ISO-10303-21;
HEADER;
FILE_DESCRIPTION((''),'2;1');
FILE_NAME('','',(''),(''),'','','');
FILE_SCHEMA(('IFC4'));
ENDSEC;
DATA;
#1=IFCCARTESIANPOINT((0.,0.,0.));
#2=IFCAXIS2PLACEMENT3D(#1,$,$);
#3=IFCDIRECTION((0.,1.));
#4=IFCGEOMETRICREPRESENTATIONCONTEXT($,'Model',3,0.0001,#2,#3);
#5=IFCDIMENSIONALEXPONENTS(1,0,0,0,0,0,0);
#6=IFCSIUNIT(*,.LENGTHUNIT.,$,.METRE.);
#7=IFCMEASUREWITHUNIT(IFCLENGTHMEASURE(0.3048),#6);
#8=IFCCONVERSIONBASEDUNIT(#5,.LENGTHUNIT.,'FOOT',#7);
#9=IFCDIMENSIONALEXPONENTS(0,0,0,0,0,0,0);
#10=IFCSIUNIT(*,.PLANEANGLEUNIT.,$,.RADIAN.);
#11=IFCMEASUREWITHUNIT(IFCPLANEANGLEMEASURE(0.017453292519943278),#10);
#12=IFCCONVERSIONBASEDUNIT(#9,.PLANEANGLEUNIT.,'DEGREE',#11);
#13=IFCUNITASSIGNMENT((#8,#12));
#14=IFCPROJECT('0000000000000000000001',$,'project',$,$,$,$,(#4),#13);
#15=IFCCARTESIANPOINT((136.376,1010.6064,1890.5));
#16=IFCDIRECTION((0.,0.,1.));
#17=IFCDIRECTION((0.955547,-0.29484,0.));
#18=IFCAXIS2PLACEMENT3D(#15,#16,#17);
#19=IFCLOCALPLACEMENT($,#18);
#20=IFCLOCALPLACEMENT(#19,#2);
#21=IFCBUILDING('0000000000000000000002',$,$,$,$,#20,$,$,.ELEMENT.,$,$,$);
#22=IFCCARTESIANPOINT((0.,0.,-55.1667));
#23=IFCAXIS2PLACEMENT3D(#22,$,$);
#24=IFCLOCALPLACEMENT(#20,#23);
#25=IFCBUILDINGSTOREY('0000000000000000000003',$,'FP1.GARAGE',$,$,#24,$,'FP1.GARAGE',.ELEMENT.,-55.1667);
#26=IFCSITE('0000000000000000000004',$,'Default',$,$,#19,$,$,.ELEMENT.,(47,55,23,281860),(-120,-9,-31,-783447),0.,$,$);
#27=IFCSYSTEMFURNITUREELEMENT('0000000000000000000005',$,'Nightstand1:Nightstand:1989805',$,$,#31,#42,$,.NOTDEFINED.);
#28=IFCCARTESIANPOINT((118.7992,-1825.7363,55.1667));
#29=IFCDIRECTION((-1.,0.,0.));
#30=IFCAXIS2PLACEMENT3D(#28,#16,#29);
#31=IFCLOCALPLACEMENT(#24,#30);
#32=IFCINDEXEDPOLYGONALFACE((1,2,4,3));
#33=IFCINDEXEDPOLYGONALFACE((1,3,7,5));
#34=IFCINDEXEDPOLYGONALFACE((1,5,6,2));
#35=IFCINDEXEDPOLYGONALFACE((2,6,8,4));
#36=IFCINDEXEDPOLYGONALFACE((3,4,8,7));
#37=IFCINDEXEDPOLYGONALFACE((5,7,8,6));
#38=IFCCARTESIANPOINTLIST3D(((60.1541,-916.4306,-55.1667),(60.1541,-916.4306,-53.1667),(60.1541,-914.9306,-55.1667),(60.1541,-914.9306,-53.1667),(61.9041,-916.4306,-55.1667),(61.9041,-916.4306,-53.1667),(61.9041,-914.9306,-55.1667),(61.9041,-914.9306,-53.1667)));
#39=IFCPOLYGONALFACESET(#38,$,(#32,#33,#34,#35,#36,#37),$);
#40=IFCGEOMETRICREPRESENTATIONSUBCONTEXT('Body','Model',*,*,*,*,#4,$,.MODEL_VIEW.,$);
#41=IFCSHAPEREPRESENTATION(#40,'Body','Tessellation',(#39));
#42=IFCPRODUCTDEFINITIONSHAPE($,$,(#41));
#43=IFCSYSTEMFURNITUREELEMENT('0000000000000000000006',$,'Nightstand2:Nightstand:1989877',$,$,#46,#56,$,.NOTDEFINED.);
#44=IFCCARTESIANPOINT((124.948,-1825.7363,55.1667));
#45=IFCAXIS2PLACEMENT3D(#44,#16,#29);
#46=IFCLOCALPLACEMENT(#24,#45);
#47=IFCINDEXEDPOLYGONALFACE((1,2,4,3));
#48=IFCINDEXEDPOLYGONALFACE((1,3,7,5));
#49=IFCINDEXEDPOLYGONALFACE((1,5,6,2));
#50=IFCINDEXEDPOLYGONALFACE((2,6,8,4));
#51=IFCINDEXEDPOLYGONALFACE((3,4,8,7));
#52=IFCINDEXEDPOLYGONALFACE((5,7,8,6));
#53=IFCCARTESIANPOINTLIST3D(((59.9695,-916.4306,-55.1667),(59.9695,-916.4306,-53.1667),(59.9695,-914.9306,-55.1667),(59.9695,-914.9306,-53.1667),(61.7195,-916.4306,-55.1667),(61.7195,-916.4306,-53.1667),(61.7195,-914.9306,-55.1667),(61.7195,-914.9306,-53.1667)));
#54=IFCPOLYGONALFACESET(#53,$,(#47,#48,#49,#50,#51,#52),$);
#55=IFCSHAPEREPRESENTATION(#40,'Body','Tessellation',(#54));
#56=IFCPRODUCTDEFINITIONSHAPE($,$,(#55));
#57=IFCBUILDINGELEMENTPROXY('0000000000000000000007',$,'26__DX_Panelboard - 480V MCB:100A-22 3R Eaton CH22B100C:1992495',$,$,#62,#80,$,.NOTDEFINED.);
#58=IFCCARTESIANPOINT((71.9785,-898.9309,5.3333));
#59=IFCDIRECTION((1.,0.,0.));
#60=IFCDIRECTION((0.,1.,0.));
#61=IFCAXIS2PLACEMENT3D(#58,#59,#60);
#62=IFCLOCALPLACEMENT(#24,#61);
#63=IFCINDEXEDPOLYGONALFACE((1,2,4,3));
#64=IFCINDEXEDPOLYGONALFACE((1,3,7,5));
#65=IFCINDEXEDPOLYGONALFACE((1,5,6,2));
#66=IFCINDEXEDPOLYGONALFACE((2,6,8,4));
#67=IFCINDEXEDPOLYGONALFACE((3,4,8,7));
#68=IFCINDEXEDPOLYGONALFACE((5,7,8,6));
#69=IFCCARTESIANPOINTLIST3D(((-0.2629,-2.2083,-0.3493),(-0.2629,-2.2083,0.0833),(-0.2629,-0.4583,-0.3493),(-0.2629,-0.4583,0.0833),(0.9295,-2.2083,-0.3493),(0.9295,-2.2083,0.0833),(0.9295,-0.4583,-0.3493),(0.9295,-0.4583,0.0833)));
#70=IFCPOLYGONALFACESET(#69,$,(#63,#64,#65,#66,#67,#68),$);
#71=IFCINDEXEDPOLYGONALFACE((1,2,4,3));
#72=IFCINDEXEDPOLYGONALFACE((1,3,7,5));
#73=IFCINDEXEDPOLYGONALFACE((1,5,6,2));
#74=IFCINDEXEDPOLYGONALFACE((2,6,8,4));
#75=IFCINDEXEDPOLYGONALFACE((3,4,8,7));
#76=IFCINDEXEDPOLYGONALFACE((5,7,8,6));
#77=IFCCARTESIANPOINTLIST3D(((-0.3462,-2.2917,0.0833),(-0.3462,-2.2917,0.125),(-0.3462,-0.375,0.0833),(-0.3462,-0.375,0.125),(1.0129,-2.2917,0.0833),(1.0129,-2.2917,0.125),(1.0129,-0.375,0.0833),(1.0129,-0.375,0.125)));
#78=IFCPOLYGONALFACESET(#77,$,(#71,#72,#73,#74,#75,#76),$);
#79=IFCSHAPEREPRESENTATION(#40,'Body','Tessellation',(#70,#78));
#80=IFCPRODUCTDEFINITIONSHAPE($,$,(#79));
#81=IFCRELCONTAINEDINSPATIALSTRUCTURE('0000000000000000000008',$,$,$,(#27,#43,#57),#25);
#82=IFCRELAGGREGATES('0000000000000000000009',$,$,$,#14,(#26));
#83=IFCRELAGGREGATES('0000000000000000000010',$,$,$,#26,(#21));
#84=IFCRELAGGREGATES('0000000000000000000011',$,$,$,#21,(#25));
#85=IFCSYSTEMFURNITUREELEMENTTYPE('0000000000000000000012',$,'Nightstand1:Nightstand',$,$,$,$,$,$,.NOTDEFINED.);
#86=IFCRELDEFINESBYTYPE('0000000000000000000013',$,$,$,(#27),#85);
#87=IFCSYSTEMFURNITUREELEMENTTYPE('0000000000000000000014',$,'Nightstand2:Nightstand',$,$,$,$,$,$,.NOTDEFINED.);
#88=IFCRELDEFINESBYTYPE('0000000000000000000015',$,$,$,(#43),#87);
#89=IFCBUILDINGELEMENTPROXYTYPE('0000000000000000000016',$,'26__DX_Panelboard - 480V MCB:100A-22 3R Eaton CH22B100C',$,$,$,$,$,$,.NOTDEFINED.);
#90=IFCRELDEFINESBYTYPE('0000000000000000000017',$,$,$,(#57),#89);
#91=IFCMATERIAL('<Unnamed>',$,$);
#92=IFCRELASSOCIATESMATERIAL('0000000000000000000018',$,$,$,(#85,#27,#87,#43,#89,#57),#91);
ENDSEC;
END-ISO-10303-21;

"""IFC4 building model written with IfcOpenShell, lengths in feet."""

from ifc_helpers import new_model, entity, si_unit, converted_unit, direction, frame, origin, place, context, subcontext, project, spatial, indexed_curve, outline, extrude, source, transform, mapped, material, type_object, type_shapes, element, save


model = new_model("IFC4")

# Units and contexts
model_context = context("Model", 3, precision=0.0001, world=origin(), true_north=direction((0.0, 1.0)))
body_context = subcontext(model_context, "Body", "Model", "MODEL_VIEW")
ifc_project = project(units=[converted_unit("LENGTHUNIT", "FOOT", entity("IfcLengthMeasure", 0.3048), si_unit("LENGTHUNIT", "METRE"), dimensions=[1, 0, 0, 0, 0, 0, 0]), converted_unit("PLANEANGLEUNIT", "DEGREE", entity("IfcPlaneAngleMeasure", 0.017453292519943278), si_unit("PLANEANGLEUNIT", "RADIAN"), dimensions=[0, 0, 0, 0, 0, 0, 0])], contexts=[model_context])

# Site, building, storey
site_placement = place(None, frame((136.376, 1010.6064, 1890.5), z_axis=(0.0, 0.0, 1.0), x_axis=(0.955547, -0.29484, 0.0)))
site = spatial("IfcSite", under=ifc_project, at=site_placement, Name="Default", CompositionType="ELEMENT", RefLatitude=(47, 55, 23, 281860), RefLongitude=(-120, -9, -31, -783447), RefElevation=0.0)
building_placement = place(site_placement, origin())
building = spatial("IfcBuilding", under=site, at=building_placement, CompositionType="ELEMENT")
storey_placement = place(building_placement, frame((0.0, 0.0, -55.1667)))
storey = spatial("IfcBuildingStorey", under=building, at=storey_placement, Name="FP1.GARAGE", LongName="FP1.GARAGE", CompositionType="ELEMENT", Elevation=-55.1667)

# Shared definitions
ifc_material_1 = material(Name="<Unnamed>")

# System furniture elements
system_furniture_element_type_1 = type_object("IfcSystemFurnitureElementType", Name="Nightstand1:Nightstand", PredefinedType="NOTDEFINED", material=ifc_material_1)
shared_shape_1 = source(origin(), body_context, "Body", "SweptSolid", [
    extrude(outline(indexed_curve([(-0.75, -0.875), (0.75, -0.875), (0.75, 0.875), (-0.75, 0.875), (-0.75, -0.875)], self_intersect=False)), frame((61.0291, -915.6806, -55.1667), z_axis=(0.0, 0.0, 1.0), x_axis=(0.0, -1.0, 0.0)), (0.0, 0.0, 1.0), 2.0),
])
type_shapes(system_furniture_element_type_1, [shared_shape_1])
system_furniture_element_1_placement = place(storey_placement, frame((118.7992, -1825.7363, 55.1667), z_axis=(0.0, 0.0, 1.0), x_axis=(-1.0, 0.0, 0.0)))
element("IfcSystemFurnitureElement", 1, at=system_furniture_element_1_placement, inside=storey, type_object=system_furniture_element_type_1, material=ifc_material_1, Name="Nightstand1:Nightstand:1989805", PredefinedType="NOTDEFINED", context=body_context, shape_type="MappedRepresentation", body=[
    mapped(shared_shape_1, transform((0.0, 0.0, 0.0), scale=1.0)),
])
system_furniture_element_type_2 = type_object("IfcSystemFurnitureElementType", Name="Nightstand2:Nightstand", PredefinedType="NOTDEFINED", material=ifc_material_1)
shared_shape_2 = source(origin(), body_context, "Body", "SweptSolid", [
    extrude(outline(indexed_curve([(-0.875, -0.75), (0.875, -0.75), (0.875, 0.75), (-0.875, 0.75), (-0.875, -0.75)], self_intersect=False)), frame((60.8445, -915.6806, -55.1667), z_axis=(0.0, 0.0, 1.0), x_axis=(-1.0, 0.0, 0.0)), (0.0, 0.0, 1.0), 2.0),
])
type_shapes(system_furniture_element_type_2, [shared_shape_2])
system_furniture_element_2_placement = place(storey_placement, frame((124.948, -1825.7363, 55.1667), z_axis=(0.0, 0.0, 1.0), x_axis=(-1.0, 0.0, 0.0)))
element("IfcSystemFurnitureElement", 2, at=system_furniture_element_2_placement, inside=storey, type_object=system_furniture_element_type_2, material=ifc_material_1, Name="Nightstand2:Nightstand:1989877", PredefinedType="NOTDEFINED", context=body_context, shape_type="MappedRepresentation", body=[
    mapped(shared_shape_2, transform((0.0, 0.0, 0.0), scale=1.0)),
])

# Building element proxy
building_element_proxy_type_1 = type_object("IfcBuildingElementProxyType", Name="26__DX_Panelboard - 480V MCB:100A-22 3R Eaton CH22B100C", PredefinedType="NOTDEFINED", material=ifc_material_1)
shared_shape_3 = source(origin(), body_context, "Body", "SweptSolid", [
    extrude(outline(indexed_curve([(-0.5962, -0.875), (0.5962, -0.875), (0.5962, 0.875), (-0.5962, 0.875), (-0.5962, -0.875)], self_intersect=False)), frame((0.3333, -1.3333, -0.3493), z_axis=(0.0, 0.0, 1.0), x_axis=(-1.0, 0.0, 0.0)), (0.0, 0.0, 1.0), 0.4326),
    extrude(outline(indexed_curve([(-0.6795, -0.9583), (0.6795, -0.9583), (0.6795, 0.9583), (-0.6795, 0.9583), (-0.6795, -0.9583)], self_intersect=False)), frame((0.3333, -1.3333, 0.0833), z_axis=(0.0, 0.0, 1.0), x_axis=(-1.0, 0.0, 0.0)), (0.0, 0.0, 1.0), 0.0417),
])
type_shapes(building_element_proxy_type_1, [shared_shape_3])
proxy_1_placement = place(storey_placement, frame((71.9785, -898.9309, 5.3333), z_axis=(1.0, 0.0, 0.0), x_axis=(0.0, 1.0, 0.0)))
element("IfcBuildingElementProxy", 3, at=proxy_1_placement, inside=storey, type_object=building_element_proxy_type_1, material=ifc_material_1, Name="26__DX_Panelboard - 480V MCB:100A-22 3R Eaton CH22B100C:1992495", PredefinedType="NOTDEFINED", context=body_context, shape_type="MappedRepresentation", body=[
    mapped(shared_shape_3, transform((0.0, 0.0, 0.0), scale=1.0)),
])

save(model, "model.ifc")
